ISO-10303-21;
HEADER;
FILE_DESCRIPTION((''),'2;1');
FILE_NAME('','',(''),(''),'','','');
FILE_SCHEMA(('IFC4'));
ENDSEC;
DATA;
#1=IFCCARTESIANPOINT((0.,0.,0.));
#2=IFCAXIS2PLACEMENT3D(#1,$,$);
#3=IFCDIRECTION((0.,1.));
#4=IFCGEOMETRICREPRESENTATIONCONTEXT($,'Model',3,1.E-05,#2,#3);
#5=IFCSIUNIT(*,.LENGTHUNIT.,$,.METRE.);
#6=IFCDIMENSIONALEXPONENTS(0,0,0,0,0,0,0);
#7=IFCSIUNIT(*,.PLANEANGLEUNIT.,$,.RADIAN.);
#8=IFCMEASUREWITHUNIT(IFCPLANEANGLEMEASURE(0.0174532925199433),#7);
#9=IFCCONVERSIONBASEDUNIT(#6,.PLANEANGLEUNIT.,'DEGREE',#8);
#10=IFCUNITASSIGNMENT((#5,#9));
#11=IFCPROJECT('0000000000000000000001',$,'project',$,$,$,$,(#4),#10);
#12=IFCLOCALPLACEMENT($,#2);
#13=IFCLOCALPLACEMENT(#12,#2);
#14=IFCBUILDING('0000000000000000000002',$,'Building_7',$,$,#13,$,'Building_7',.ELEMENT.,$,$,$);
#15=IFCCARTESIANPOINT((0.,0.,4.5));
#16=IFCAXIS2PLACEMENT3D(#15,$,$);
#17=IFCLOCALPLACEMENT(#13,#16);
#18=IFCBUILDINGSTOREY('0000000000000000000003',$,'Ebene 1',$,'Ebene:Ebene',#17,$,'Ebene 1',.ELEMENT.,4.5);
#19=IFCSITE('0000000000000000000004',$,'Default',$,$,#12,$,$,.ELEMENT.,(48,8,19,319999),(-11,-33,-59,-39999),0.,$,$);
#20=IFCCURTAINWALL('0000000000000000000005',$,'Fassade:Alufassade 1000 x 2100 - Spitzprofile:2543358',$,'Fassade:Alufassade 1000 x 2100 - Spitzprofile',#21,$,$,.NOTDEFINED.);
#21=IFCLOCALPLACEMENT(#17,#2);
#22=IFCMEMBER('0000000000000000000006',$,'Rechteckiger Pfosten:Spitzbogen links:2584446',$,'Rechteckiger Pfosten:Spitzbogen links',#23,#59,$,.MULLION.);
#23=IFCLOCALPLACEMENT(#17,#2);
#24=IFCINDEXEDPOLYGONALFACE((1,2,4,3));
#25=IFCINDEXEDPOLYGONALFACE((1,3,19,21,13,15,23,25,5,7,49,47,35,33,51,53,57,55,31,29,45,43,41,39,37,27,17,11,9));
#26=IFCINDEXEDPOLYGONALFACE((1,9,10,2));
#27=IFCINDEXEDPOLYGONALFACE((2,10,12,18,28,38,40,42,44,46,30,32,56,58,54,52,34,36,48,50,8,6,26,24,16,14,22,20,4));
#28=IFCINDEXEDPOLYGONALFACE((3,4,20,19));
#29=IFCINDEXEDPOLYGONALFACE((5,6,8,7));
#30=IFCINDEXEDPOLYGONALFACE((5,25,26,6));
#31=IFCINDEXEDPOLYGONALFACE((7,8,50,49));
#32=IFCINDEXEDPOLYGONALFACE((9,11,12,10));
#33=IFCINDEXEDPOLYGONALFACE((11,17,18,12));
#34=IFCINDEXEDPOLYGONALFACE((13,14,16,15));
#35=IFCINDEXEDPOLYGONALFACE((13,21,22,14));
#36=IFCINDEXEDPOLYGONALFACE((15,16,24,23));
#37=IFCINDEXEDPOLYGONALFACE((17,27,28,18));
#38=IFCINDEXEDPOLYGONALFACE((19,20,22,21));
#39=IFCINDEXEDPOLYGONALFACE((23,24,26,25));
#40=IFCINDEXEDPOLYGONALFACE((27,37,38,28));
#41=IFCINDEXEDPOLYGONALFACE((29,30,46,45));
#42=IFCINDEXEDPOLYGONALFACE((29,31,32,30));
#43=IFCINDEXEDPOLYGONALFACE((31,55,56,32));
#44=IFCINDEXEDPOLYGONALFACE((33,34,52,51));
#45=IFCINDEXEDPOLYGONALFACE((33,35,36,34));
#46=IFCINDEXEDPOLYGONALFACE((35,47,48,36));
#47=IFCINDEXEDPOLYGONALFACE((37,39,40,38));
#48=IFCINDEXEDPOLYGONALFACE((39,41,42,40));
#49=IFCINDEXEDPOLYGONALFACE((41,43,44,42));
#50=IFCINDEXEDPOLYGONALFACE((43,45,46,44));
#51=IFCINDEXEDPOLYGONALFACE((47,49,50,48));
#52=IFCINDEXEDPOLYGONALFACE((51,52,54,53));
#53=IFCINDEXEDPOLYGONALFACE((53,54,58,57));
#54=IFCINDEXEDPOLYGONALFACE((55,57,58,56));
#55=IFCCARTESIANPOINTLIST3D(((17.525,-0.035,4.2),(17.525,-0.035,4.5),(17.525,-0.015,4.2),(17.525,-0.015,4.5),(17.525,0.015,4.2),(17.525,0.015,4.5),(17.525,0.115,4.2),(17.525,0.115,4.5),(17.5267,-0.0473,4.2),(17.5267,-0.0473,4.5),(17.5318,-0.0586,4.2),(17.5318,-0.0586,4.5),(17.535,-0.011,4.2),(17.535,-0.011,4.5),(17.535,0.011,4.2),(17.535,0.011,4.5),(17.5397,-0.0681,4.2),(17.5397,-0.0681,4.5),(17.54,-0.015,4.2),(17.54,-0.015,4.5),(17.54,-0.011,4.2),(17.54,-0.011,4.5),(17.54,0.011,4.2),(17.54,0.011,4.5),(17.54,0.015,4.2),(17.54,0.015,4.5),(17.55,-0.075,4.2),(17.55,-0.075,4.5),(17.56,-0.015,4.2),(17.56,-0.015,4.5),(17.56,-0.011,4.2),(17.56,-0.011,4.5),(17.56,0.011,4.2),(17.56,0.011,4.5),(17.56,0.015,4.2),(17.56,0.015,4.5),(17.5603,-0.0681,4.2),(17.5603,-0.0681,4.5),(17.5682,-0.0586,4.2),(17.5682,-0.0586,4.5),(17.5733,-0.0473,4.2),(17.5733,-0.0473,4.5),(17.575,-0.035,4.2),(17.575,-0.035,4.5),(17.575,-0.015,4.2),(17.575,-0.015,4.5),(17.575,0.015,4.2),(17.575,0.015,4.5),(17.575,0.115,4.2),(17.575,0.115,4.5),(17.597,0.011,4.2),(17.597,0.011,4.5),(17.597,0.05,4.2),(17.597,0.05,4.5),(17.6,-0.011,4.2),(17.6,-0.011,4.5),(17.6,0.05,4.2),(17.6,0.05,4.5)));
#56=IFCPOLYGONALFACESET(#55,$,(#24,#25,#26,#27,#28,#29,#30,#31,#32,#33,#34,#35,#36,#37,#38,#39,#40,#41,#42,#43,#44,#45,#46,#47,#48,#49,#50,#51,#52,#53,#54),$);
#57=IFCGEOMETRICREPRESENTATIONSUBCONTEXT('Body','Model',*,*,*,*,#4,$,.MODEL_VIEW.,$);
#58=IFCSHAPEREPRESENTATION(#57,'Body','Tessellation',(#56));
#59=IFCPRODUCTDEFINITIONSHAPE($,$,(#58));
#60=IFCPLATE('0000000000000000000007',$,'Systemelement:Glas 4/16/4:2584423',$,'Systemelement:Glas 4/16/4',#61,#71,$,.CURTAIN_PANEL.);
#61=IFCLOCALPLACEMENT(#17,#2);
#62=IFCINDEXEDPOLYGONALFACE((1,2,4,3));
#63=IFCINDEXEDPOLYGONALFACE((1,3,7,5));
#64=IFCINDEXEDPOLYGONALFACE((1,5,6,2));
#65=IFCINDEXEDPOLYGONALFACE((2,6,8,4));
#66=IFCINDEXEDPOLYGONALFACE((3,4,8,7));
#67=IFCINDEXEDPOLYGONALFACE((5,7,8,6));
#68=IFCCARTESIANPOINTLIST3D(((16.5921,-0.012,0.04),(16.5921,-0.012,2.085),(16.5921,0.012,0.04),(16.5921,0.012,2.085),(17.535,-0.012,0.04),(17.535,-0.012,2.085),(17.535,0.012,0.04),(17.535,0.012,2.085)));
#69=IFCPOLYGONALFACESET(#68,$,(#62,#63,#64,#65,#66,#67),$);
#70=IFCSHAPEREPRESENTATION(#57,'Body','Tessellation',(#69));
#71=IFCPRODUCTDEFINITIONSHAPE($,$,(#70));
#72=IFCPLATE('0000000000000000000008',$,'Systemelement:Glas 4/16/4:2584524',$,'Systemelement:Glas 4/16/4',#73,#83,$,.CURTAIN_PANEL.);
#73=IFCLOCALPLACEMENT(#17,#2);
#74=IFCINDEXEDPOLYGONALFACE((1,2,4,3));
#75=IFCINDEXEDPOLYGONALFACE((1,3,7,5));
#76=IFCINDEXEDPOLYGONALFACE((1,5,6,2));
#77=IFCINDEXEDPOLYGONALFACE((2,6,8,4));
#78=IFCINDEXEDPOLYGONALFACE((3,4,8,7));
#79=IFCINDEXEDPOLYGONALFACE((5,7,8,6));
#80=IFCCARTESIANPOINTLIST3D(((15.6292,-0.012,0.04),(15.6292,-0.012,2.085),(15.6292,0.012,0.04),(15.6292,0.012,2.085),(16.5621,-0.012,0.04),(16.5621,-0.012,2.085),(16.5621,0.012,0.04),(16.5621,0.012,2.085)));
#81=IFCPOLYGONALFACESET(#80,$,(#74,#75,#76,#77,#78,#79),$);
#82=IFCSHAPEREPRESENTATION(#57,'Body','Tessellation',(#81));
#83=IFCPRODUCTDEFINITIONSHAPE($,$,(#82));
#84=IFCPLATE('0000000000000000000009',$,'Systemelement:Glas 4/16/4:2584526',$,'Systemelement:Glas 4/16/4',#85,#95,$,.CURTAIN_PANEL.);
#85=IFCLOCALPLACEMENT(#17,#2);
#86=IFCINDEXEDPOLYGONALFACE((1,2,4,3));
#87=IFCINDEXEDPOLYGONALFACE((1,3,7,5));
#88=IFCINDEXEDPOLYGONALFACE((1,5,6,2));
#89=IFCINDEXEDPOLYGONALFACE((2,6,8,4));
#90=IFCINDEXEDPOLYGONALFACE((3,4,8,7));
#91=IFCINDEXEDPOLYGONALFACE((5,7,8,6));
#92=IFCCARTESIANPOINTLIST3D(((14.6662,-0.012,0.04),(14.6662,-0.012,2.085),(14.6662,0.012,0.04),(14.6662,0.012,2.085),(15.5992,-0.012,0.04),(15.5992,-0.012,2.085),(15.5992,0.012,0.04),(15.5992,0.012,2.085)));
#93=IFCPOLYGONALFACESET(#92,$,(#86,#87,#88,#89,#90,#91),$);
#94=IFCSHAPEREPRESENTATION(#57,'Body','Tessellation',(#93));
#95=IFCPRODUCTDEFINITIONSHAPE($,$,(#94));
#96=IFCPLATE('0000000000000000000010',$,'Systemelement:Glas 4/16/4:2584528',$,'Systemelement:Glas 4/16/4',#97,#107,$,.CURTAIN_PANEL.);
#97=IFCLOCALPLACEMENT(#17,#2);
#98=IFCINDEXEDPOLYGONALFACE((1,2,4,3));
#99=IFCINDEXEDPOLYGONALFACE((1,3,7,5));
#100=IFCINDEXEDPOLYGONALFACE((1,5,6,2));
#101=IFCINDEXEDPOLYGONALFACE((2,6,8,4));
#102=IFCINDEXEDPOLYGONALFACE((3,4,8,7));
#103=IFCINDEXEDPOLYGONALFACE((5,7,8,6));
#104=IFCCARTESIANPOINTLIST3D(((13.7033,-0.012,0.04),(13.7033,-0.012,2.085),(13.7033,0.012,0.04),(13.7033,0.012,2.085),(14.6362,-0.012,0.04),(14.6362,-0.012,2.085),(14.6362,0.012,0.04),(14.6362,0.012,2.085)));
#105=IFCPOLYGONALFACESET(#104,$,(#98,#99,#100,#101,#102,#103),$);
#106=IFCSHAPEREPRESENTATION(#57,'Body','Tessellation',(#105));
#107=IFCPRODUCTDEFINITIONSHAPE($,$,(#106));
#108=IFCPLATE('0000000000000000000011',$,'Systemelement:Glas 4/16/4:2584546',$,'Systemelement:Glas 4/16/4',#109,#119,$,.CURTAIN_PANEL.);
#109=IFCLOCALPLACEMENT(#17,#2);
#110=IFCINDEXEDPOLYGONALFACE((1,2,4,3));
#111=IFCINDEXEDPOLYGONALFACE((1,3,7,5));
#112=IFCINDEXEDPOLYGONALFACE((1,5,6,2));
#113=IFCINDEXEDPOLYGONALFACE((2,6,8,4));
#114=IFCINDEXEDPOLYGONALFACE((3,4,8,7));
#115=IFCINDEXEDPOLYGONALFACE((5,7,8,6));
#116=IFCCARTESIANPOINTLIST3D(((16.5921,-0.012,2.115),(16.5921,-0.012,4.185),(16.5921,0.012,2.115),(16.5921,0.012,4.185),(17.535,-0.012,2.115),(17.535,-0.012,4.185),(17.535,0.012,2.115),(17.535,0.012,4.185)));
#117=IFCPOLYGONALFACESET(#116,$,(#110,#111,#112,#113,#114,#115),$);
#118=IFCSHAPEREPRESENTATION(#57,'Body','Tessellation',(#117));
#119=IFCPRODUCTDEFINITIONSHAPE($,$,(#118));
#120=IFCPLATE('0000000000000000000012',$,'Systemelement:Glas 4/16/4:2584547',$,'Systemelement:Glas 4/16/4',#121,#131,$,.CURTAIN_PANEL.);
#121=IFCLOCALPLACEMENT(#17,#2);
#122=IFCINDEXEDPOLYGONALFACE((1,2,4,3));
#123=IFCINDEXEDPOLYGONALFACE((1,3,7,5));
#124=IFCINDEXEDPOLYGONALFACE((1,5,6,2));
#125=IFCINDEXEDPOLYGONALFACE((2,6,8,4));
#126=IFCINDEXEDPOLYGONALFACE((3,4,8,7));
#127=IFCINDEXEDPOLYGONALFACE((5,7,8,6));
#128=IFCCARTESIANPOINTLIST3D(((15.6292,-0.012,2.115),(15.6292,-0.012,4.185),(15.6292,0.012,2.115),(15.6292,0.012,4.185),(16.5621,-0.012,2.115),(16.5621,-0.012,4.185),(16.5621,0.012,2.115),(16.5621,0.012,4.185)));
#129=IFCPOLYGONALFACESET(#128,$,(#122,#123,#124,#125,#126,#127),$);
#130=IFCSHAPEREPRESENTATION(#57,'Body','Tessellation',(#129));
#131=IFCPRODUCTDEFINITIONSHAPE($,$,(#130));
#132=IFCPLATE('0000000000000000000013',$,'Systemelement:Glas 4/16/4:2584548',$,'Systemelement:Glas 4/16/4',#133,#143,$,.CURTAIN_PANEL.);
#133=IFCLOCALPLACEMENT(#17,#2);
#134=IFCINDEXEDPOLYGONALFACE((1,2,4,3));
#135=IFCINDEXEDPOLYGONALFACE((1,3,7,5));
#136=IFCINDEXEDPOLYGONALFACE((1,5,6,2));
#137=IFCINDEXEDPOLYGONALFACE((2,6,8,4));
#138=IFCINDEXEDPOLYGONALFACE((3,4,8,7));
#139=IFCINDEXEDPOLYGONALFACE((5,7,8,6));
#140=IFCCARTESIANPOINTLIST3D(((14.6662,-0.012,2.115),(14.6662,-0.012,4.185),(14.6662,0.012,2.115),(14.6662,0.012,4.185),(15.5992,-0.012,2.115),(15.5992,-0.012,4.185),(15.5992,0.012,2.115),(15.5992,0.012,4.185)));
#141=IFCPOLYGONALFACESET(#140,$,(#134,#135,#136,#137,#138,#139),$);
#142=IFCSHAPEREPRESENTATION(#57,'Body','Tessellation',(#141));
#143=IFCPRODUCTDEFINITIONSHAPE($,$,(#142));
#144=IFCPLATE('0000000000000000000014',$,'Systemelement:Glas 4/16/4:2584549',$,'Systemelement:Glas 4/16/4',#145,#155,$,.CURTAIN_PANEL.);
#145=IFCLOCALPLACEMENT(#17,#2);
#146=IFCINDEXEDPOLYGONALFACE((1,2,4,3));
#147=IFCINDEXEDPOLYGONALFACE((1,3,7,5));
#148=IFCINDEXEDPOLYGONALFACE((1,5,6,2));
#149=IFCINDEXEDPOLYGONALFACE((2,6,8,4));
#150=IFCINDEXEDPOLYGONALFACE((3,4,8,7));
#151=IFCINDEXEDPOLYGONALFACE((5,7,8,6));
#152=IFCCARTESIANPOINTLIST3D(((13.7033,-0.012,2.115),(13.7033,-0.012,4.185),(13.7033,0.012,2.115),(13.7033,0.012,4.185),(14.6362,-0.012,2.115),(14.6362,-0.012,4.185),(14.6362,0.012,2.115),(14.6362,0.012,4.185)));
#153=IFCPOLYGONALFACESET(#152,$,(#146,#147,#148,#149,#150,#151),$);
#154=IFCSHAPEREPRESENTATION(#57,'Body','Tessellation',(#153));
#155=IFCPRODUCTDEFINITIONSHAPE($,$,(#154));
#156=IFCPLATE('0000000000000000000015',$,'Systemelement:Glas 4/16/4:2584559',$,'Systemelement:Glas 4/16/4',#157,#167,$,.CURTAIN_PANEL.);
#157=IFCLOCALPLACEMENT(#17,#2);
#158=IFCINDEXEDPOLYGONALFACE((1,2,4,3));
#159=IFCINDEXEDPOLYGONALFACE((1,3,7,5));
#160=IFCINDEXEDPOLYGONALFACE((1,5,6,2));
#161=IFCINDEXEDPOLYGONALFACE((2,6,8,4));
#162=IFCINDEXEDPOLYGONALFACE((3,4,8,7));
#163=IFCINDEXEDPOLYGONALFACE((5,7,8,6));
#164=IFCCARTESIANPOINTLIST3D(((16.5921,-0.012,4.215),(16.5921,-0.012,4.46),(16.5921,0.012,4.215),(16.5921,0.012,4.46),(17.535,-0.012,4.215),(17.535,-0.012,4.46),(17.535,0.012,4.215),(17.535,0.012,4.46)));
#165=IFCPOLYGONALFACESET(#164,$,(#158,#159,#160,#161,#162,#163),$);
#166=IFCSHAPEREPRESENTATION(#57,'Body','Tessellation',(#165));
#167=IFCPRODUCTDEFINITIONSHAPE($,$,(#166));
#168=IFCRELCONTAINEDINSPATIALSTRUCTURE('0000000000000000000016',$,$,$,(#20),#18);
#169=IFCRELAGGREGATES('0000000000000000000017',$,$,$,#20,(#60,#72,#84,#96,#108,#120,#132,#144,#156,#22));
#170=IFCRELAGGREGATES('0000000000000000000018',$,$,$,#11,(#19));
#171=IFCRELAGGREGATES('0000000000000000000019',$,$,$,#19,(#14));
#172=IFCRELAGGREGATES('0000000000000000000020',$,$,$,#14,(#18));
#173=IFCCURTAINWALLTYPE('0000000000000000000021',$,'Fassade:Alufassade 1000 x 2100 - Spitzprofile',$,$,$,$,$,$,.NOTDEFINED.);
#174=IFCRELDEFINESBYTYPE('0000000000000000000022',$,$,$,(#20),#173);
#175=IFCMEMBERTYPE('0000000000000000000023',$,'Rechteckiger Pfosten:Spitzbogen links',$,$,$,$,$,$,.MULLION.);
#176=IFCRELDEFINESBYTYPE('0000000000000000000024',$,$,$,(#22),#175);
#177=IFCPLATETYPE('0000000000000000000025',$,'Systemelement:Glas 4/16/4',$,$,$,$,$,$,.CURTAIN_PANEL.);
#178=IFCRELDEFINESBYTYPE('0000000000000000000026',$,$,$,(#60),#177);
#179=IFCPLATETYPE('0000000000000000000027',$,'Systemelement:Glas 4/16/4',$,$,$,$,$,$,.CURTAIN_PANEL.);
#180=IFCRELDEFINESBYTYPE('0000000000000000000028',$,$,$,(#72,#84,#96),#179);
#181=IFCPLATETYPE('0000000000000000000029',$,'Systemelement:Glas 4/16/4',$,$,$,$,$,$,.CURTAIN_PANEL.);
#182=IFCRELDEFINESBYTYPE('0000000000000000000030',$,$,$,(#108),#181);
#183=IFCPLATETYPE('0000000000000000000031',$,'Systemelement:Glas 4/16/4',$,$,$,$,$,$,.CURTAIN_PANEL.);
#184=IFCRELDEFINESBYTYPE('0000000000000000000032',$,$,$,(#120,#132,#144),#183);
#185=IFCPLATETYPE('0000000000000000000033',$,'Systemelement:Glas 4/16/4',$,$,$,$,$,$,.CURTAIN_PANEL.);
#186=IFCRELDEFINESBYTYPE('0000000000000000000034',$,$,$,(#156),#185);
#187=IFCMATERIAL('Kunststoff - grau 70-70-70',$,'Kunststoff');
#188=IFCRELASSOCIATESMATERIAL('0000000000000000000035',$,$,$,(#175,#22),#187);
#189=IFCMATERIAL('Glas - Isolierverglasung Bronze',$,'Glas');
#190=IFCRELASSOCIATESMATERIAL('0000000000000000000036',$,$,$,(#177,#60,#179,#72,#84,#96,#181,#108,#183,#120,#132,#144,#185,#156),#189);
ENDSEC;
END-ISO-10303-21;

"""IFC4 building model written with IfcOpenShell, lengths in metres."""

from ifc_helpers import new_model, entity, si_unit, converted_unit, direction, frame, origin, place, context, subcontext, project, spatial, line, arc, indexed_curve, outline, extrude, source, transform, mapped, material, type_object, type_shapes, element, aggregate, save


model = new_model("IFC4")

# Units and contexts
model_context = context("Model", 3, precision=1e-05, world=origin(), true_north=direction((0.0, 1.0)))
body_context = subcontext(model_context, "Body", "Model", "MODEL_VIEW")
ifc_project = project(units=[si_unit("LENGTHUNIT", "METRE"), converted_unit("PLANEANGLEUNIT", "DEGREE", entity("IfcPlaneAngleMeasure", 0.0174532925199433), si_unit("PLANEANGLEUNIT", "RADIAN"), dimensions=[0, 0, 0, 0, 0, 0, 0])], contexts=[model_context])

# Site, building, storey
site_placement = place(None, origin())
site = spatial("IfcSite", under=ifc_project, at=site_placement, Name="Default", CompositionType="ELEMENT", RefLatitude=(48, 8, 19, 319999), RefLongitude=(-11, -33, -59, -39999), RefElevation=0.0)
building_placement = place(site_placement, origin())
building = spatial("IfcBuilding", under=site, at=building_placement, Name="Building_7", LongName="Building_7", CompositionType="ELEMENT")
storey_placement = place(building_placement, frame((0.0, 0.0, 4.5)))
storey = spatial("IfcBuildingStorey", under=building, at=storey_placement, Name="Ebene 1", ObjectType="Ebene:Ebene", LongName="Ebene 1", CompositionType="ELEMENT", Elevation=4.5)

# Curtain wall, member, plates
curtain_wall_type = type_object("IfcCurtainWallType", Name="Fassade:Alufassade 1000 x 2100 - Spitzprofile", PredefinedType="NOTDEFINED")
curtain_wall_placement = place(storey_placement, frame((0.0, 0.0, -4.5)))
curtain_wall = element("IfcCurtainWall", 1, at=curtain_wall_placement, inside=storey, type_object=curtain_wall_type, Name="Fassade:Alufassade 1000 x 2100 - Spitzprofile:2543358", ObjectType="Fassade:Alufassade 1000 x 2100 - Spitzprofile", PredefinedType="NOTDEFINED")
ifc_material_1 = material(Name="Kunststoff - grau 70-70-70", Category="Kunststoff")
member_type_1 = type_object("IfcMemberType", Name="Rechteckiger Pfosten:Spitzbogen links", PredefinedType="MULLION", material=ifc_material_1)
shared_shape_1 = source(origin(), body_context, "Body", "SweptSolid", [
    extrude(outline(indexed_curve([(-0.107, -0.0321), (-0.007, -0.0321), (-0.007, -0.0171), (-0.003, -0.0171), (-0.003, -0.0221), (0.019, -0.0221), (0.019, -0.0171), (0.023, -0.0171), (0.023, -0.0321), (0.043, -0.0321), (0.0666, -0.0254), (0.083, -0.0071), (0.0666, 0.0111), (0.043, 0.0179), (0.023, 0.0179), (0.023, 0.0029), (0.019, 0.0029), (0.019, 0.0429), (-0.042, 0.0429), (-0.042, 0.0399), (-0.003, 0.0399), (-0.003, 0.0029), (-0.007, 0.0029), (-0.007, 0.0179), (-0.107, 0.0179)], segments=[line(1, 2, 3, 4, 5, 6, 7, 8, 9, 10), arc(10, 11, 12), arc(12, 13, 14), line(14, 15, 16, 17, 18, 19, 20, 21, 22, 23, 24, 25, 1)], self_intersect=False)), frame((-0.0429, 0.008, -0.3), z_axis=(0.0, 0.0, 1.0), x_axis=(0.0, -1.0, 0.0)), (0.0, 0.0, 1.0), 0.3),
])
type_shapes(member_type_1, [shared_shape_1])
member_1_placement = place(curtain_wall_placement, frame((17.6, 0.0, 9.0)))
member_1 = element("IfcMember", 2, at=member_1_placement, type_object=member_type_1, material=ifc_material_1, Name="Rechteckiger Pfosten:Spitzbogen links:2584446", ObjectType="Rechteckiger Pfosten:Spitzbogen links", PredefinedType="MULLION", context=body_context, shape_type="MappedRepresentation", body=[
    mapped(shared_shape_1, transform((0.0, 0.0, 0.0), scale=1.0)),
])
ifc_material_2 = material(Name="Glas - Isolierverglasung Bronze", Category="Glas")
plate_type_1 = type_object("IfcPlateType", Name="Systemelement:Glas 4/16/4", PredefinedType="CURTAIN_PANEL", material=ifc_material_2)
shared_shape_2 = source(origin(), body_context, "Body", "SweptSolid", [
    extrude(outline(indexed_curve([(-0.012, -0.4715), (0.012, -0.4715), (0.012, 0.4715), (-0.012, 0.4715), (-0.012, -0.4715)], self_intersect=False)), frame((0.0, 0.0, 0.0), z_axis=(0.0, 0.0, 1.0), x_axis=(0.0, 1.0, 0.0)), (0.0, 0.0, 1.0), 2.045),
])
type_shapes(plate_type_1, [shared_shape_2])
plate_1_placement = place(curtain_wall_placement, frame((17.0635, 0.0, 4.54), z_axis=(0.0, 0.0, 1.0), x_axis=(-1.0, 0.0, 0.0)))
plate_1 = element("IfcPlate", 3, at=plate_1_placement, type_object=plate_type_1, material=ifc_material_2, Name="Systemelement:Glas 4/16/4:2584423", ObjectType="Systemelement:Glas 4/16/4", PredefinedType="CURTAIN_PANEL", context=body_context, shape_type="MappedRepresentation", body=[
    mapped(shared_shape_2, transform((0.0, 0.0, 0.0), scale=1.0)),
])
plate_type_2 = type_object("IfcPlateType", Name="Systemelement:Glas 4/16/4", PredefinedType="CURTAIN_PANEL", material=ifc_material_2)
shared_shape_3 = source(origin(), body_context, "Body", "SweptSolid", [
    extrude(outline(indexed_curve([(-0.012, -0.4665), (0.012, -0.4665), (0.012, 0.4665), (-0.012, 0.4665), (-0.012, -0.4665)], self_intersect=False)), frame((0.0, 0.0, 0.0), z_axis=(0.0, 0.0, 1.0), x_axis=(0.0, 1.0, 0.0)), (0.0, 0.0, 1.0), 2.045),
])
type_shapes(plate_type_2, [shared_shape_3])
plate_2_placement = place(curtain_wall_placement, frame((16.0956, 0.0, 4.54), z_axis=(0.0, 0.0, 1.0), x_axis=(-1.0, 0.0, 0.0)))
plate_2 = element("IfcPlate", 4, at=plate_2_placement, type_object=plate_type_2, material=ifc_material_2, Name="Systemelement:Glas 4/16/4:2584524", ObjectType="Systemelement:Glas 4/16/4", PredefinedType="CURTAIN_PANEL", context=body_context, shape_type="MappedRepresentation", body=[
    mapped(shared_shape_3, transform((0.0, 0.0, 0.0), scale=1.0)),
])
plate_3_placement = place(curtain_wall_placement, frame((15.1327, 0.0, 4.54), z_axis=(0.0, 0.0, 1.0), x_axis=(-1.0, 0.0, 0.0)))
plate_3 = element("IfcPlate", 5, at=plate_3_placement, type_object=plate_type_2, material=ifc_material_2, Name="Systemelement:Glas 4/16/4:2584526", ObjectType="Systemelement:Glas 4/16/4", PredefinedType="CURTAIN_PANEL", context=body_context, shape_type="MappedRepresentation", body=[
    mapped(shared_shape_3, transform((0.0, 0.0, 0.0), scale=1.0)),
])
plate_4_placement = place(curtain_wall_placement, frame((14.1698, 0.0, 4.54), z_axis=(0.0, 0.0, 1.0), x_axis=(-1.0, 0.0, 0.0)))
plate_4 = element("IfcPlate", 6, at=plate_4_placement, type_object=plate_type_2, material=ifc_material_2, Name="Systemelement:Glas 4/16/4:2584528", ObjectType="Systemelement:Glas 4/16/4", PredefinedType="CURTAIN_PANEL", context=body_context, shape_type="MappedRepresentation", body=[
    mapped(shared_shape_3, transform((0.0, 0.0, 0.0), scale=1.0)),
])
plate_type_3 = type_object("IfcPlateType", Name="Systemelement:Glas 4/16/4", PredefinedType="CURTAIN_PANEL", material=ifc_material_2)
shared_shape_4 = source(origin(), body_context, "Body", "SweptSolid", [
    extrude(outline(indexed_curve([(-0.012, -0.4715), (0.012, -0.4715), (0.012, 0.4715), (-0.012, 0.4715), (-0.012, -0.4715)], self_intersect=False)), frame((0.0, 0.0, 0.0), z_axis=(0.0, 0.0, 1.0), x_axis=(0.0, 1.0, 0.0)), (0.0, 0.0, 1.0), 2.07),
])
type_shapes(plate_type_3, [shared_shape_4])
plate_5_placement = place(curtain_wall_placement, frame((17.0635, 0.0, 6.615), z_axis=(0.0, 0.0, 1.0), x_axis=(-1.0, 0.0, 0.0)))
plate_5 = element("IfcPlate", 7, at=plate_5_placement, type_object=plate_type_3, material=ifc_material_2, Name="Systemelement:Glas 4/16/4:2584546", ObjectType="Systemelement:Glas 4/16/4", PredefinedType="CURTAIN_PANEL", context=body_context, shape_type="MappedRepresentation", body=[
    mapped(shared_shape_4, transform((0.0, 0.0, 0.0), scale=1.0)),
])
plate_type_4 = type_object("IfcPlateType", Name="Systemelement:Glas 4/16/4", PredefinedType="CURTAIN_PANEL", material=ifc_material_2)
shared_shape_5 = source(origin(), body_context, "Body", "SweptSolid", [
    extrude(outline(indexed_curve([(-0.012, -0.4665), (0.012, -0.4665), (0.012, 0.4665), (-0.012, 0.4665), (-0.012, -0.4665)], self_intersect=False)), frame((0.0, 0.0, 0.0), z_axis=(0.0, 0.0, 1.0), x_axis=(0.0, 1.0, 0.0)), (0.0, 0.0, 1.0), 2.07),
])
type_shapes(plate_type_4, [shared_shape_5])
plate_6_placement = place(curtain_wall_placement, frame((16.0956, 0.0, 6.615), z_axis=(0.0, 0.0, 1.0), x_axis=(-1.0, 0.0, 0.0)))
plate_6 = element("IfcPlate", 8, at=plate_6_placement, type_object=plate_type_4, material=ifc_material_2, Name="Systemelement:Glas 4/16/4:2584547", ObjectType="Systemelement:Glas 4/16/4", PredefinedType="CURTAIN_PANEL", context=body_context, shape_type="MappedRepresentation", body=[
    mapped(shared_shape_5, transform((0.0, 0.0, 0.0), scale=1.0)),
])
plate_7_placement = place(curtain_wall_placement, frame((15.1327, 0.0, 6.615), z_axis=(0.0, 0.0, 1.0), x_axis=(-1.0, 0.0, 0.0)))
plate_7 = element("IfcPlate", 9, at=plate_7_placement, type_object=plate_type_4, material=ifc_material_2, Name="Systemelement:Glas 4/16/4:2584548", ObjectType="Systemelement:Glas 4/16/4", PredefinedType="CURTAIN_PANEL", context=body_context, shape_type="MappedRepresentation", body=[
    mapped(shared_shape_5, transform((0.0, 0.0, 0.0), scale=1.0)),
])
plate_8_placement = place(curtain_wall_placement, frame((14.1698, 0.0, 6.615), z_axis=(0.0, 0.0, 1.0), x_axis=(-1.0, 0.0, 0.0)))
plate_8 = element("IfcPlate", 10, at=plate_8_placement, type_object=plate_type_4, material=ifc_material_2, Name="Systemelement:Glas 4/16/4:2584549", ObjectType="Systemelement:Glas 4/16/4", PredefinedType="CURTAIN_PANEL", context=body_context, shape_type="MappedRepresentation", body=[
    mapped(shared_shape_5, transform((0.0, 0.0, 0.0), scale=1.0)),
])
plate_type_5 = type_object("IfcPlateType", Name="Systemelement:Glas 4/16/4", PredefinedType="CURTAIN_PANEL", material=ifc_material_2)
shared_shape_6 = source(origin(), body_context, "Body", "SweptSolid", [
    extrude(outline(indexed_curve([(-0.012, -0.4715), (0.012, -0.4715), (0.012, 0.4715), (-0.012, 0.4715), (-0.012, -0.4715)], self_intersect=False)), frame((0.0, 0.0, 0.0), z_axis=(0.0, 0.0, 1.0), x_axis=(0.0, 1.0, 0.0)), (0.0, 0.0, 1.0), 0.245),
])
type_shapes(plate_type_5, [shared_shape_6])
plate_9_placement = place(curtain_wall_placement, frame((17.0635, 0.0, 8.715), z_axis=(0.0, 0.0, 1.0), x_axis=(-1.0, 0.0, 0.0)))
plate_9 = element("IfcPlate", 11, at=plate_9_placement, type_object=plate_type_5, material=ifc_material_2, Name="Systemelement:Glas 4/16/4:2584559", ObjectType="Systemelement:Glas 4/16/4", PredefinedType="CURTAIN_PANEL", context=body_context, shape_type="MappedRepresentation", body=[
    mapped(shared_shape_6, transform((0.0, 0.0, 0.0), scale=1.0)),
])
aggregate(curtain_wall, [plate_1, plate_2, plate_3, plate_4, plate_5, plate_6, plate_7, plate_8, plate_9, member_1])

save(model, "model.ifc")
